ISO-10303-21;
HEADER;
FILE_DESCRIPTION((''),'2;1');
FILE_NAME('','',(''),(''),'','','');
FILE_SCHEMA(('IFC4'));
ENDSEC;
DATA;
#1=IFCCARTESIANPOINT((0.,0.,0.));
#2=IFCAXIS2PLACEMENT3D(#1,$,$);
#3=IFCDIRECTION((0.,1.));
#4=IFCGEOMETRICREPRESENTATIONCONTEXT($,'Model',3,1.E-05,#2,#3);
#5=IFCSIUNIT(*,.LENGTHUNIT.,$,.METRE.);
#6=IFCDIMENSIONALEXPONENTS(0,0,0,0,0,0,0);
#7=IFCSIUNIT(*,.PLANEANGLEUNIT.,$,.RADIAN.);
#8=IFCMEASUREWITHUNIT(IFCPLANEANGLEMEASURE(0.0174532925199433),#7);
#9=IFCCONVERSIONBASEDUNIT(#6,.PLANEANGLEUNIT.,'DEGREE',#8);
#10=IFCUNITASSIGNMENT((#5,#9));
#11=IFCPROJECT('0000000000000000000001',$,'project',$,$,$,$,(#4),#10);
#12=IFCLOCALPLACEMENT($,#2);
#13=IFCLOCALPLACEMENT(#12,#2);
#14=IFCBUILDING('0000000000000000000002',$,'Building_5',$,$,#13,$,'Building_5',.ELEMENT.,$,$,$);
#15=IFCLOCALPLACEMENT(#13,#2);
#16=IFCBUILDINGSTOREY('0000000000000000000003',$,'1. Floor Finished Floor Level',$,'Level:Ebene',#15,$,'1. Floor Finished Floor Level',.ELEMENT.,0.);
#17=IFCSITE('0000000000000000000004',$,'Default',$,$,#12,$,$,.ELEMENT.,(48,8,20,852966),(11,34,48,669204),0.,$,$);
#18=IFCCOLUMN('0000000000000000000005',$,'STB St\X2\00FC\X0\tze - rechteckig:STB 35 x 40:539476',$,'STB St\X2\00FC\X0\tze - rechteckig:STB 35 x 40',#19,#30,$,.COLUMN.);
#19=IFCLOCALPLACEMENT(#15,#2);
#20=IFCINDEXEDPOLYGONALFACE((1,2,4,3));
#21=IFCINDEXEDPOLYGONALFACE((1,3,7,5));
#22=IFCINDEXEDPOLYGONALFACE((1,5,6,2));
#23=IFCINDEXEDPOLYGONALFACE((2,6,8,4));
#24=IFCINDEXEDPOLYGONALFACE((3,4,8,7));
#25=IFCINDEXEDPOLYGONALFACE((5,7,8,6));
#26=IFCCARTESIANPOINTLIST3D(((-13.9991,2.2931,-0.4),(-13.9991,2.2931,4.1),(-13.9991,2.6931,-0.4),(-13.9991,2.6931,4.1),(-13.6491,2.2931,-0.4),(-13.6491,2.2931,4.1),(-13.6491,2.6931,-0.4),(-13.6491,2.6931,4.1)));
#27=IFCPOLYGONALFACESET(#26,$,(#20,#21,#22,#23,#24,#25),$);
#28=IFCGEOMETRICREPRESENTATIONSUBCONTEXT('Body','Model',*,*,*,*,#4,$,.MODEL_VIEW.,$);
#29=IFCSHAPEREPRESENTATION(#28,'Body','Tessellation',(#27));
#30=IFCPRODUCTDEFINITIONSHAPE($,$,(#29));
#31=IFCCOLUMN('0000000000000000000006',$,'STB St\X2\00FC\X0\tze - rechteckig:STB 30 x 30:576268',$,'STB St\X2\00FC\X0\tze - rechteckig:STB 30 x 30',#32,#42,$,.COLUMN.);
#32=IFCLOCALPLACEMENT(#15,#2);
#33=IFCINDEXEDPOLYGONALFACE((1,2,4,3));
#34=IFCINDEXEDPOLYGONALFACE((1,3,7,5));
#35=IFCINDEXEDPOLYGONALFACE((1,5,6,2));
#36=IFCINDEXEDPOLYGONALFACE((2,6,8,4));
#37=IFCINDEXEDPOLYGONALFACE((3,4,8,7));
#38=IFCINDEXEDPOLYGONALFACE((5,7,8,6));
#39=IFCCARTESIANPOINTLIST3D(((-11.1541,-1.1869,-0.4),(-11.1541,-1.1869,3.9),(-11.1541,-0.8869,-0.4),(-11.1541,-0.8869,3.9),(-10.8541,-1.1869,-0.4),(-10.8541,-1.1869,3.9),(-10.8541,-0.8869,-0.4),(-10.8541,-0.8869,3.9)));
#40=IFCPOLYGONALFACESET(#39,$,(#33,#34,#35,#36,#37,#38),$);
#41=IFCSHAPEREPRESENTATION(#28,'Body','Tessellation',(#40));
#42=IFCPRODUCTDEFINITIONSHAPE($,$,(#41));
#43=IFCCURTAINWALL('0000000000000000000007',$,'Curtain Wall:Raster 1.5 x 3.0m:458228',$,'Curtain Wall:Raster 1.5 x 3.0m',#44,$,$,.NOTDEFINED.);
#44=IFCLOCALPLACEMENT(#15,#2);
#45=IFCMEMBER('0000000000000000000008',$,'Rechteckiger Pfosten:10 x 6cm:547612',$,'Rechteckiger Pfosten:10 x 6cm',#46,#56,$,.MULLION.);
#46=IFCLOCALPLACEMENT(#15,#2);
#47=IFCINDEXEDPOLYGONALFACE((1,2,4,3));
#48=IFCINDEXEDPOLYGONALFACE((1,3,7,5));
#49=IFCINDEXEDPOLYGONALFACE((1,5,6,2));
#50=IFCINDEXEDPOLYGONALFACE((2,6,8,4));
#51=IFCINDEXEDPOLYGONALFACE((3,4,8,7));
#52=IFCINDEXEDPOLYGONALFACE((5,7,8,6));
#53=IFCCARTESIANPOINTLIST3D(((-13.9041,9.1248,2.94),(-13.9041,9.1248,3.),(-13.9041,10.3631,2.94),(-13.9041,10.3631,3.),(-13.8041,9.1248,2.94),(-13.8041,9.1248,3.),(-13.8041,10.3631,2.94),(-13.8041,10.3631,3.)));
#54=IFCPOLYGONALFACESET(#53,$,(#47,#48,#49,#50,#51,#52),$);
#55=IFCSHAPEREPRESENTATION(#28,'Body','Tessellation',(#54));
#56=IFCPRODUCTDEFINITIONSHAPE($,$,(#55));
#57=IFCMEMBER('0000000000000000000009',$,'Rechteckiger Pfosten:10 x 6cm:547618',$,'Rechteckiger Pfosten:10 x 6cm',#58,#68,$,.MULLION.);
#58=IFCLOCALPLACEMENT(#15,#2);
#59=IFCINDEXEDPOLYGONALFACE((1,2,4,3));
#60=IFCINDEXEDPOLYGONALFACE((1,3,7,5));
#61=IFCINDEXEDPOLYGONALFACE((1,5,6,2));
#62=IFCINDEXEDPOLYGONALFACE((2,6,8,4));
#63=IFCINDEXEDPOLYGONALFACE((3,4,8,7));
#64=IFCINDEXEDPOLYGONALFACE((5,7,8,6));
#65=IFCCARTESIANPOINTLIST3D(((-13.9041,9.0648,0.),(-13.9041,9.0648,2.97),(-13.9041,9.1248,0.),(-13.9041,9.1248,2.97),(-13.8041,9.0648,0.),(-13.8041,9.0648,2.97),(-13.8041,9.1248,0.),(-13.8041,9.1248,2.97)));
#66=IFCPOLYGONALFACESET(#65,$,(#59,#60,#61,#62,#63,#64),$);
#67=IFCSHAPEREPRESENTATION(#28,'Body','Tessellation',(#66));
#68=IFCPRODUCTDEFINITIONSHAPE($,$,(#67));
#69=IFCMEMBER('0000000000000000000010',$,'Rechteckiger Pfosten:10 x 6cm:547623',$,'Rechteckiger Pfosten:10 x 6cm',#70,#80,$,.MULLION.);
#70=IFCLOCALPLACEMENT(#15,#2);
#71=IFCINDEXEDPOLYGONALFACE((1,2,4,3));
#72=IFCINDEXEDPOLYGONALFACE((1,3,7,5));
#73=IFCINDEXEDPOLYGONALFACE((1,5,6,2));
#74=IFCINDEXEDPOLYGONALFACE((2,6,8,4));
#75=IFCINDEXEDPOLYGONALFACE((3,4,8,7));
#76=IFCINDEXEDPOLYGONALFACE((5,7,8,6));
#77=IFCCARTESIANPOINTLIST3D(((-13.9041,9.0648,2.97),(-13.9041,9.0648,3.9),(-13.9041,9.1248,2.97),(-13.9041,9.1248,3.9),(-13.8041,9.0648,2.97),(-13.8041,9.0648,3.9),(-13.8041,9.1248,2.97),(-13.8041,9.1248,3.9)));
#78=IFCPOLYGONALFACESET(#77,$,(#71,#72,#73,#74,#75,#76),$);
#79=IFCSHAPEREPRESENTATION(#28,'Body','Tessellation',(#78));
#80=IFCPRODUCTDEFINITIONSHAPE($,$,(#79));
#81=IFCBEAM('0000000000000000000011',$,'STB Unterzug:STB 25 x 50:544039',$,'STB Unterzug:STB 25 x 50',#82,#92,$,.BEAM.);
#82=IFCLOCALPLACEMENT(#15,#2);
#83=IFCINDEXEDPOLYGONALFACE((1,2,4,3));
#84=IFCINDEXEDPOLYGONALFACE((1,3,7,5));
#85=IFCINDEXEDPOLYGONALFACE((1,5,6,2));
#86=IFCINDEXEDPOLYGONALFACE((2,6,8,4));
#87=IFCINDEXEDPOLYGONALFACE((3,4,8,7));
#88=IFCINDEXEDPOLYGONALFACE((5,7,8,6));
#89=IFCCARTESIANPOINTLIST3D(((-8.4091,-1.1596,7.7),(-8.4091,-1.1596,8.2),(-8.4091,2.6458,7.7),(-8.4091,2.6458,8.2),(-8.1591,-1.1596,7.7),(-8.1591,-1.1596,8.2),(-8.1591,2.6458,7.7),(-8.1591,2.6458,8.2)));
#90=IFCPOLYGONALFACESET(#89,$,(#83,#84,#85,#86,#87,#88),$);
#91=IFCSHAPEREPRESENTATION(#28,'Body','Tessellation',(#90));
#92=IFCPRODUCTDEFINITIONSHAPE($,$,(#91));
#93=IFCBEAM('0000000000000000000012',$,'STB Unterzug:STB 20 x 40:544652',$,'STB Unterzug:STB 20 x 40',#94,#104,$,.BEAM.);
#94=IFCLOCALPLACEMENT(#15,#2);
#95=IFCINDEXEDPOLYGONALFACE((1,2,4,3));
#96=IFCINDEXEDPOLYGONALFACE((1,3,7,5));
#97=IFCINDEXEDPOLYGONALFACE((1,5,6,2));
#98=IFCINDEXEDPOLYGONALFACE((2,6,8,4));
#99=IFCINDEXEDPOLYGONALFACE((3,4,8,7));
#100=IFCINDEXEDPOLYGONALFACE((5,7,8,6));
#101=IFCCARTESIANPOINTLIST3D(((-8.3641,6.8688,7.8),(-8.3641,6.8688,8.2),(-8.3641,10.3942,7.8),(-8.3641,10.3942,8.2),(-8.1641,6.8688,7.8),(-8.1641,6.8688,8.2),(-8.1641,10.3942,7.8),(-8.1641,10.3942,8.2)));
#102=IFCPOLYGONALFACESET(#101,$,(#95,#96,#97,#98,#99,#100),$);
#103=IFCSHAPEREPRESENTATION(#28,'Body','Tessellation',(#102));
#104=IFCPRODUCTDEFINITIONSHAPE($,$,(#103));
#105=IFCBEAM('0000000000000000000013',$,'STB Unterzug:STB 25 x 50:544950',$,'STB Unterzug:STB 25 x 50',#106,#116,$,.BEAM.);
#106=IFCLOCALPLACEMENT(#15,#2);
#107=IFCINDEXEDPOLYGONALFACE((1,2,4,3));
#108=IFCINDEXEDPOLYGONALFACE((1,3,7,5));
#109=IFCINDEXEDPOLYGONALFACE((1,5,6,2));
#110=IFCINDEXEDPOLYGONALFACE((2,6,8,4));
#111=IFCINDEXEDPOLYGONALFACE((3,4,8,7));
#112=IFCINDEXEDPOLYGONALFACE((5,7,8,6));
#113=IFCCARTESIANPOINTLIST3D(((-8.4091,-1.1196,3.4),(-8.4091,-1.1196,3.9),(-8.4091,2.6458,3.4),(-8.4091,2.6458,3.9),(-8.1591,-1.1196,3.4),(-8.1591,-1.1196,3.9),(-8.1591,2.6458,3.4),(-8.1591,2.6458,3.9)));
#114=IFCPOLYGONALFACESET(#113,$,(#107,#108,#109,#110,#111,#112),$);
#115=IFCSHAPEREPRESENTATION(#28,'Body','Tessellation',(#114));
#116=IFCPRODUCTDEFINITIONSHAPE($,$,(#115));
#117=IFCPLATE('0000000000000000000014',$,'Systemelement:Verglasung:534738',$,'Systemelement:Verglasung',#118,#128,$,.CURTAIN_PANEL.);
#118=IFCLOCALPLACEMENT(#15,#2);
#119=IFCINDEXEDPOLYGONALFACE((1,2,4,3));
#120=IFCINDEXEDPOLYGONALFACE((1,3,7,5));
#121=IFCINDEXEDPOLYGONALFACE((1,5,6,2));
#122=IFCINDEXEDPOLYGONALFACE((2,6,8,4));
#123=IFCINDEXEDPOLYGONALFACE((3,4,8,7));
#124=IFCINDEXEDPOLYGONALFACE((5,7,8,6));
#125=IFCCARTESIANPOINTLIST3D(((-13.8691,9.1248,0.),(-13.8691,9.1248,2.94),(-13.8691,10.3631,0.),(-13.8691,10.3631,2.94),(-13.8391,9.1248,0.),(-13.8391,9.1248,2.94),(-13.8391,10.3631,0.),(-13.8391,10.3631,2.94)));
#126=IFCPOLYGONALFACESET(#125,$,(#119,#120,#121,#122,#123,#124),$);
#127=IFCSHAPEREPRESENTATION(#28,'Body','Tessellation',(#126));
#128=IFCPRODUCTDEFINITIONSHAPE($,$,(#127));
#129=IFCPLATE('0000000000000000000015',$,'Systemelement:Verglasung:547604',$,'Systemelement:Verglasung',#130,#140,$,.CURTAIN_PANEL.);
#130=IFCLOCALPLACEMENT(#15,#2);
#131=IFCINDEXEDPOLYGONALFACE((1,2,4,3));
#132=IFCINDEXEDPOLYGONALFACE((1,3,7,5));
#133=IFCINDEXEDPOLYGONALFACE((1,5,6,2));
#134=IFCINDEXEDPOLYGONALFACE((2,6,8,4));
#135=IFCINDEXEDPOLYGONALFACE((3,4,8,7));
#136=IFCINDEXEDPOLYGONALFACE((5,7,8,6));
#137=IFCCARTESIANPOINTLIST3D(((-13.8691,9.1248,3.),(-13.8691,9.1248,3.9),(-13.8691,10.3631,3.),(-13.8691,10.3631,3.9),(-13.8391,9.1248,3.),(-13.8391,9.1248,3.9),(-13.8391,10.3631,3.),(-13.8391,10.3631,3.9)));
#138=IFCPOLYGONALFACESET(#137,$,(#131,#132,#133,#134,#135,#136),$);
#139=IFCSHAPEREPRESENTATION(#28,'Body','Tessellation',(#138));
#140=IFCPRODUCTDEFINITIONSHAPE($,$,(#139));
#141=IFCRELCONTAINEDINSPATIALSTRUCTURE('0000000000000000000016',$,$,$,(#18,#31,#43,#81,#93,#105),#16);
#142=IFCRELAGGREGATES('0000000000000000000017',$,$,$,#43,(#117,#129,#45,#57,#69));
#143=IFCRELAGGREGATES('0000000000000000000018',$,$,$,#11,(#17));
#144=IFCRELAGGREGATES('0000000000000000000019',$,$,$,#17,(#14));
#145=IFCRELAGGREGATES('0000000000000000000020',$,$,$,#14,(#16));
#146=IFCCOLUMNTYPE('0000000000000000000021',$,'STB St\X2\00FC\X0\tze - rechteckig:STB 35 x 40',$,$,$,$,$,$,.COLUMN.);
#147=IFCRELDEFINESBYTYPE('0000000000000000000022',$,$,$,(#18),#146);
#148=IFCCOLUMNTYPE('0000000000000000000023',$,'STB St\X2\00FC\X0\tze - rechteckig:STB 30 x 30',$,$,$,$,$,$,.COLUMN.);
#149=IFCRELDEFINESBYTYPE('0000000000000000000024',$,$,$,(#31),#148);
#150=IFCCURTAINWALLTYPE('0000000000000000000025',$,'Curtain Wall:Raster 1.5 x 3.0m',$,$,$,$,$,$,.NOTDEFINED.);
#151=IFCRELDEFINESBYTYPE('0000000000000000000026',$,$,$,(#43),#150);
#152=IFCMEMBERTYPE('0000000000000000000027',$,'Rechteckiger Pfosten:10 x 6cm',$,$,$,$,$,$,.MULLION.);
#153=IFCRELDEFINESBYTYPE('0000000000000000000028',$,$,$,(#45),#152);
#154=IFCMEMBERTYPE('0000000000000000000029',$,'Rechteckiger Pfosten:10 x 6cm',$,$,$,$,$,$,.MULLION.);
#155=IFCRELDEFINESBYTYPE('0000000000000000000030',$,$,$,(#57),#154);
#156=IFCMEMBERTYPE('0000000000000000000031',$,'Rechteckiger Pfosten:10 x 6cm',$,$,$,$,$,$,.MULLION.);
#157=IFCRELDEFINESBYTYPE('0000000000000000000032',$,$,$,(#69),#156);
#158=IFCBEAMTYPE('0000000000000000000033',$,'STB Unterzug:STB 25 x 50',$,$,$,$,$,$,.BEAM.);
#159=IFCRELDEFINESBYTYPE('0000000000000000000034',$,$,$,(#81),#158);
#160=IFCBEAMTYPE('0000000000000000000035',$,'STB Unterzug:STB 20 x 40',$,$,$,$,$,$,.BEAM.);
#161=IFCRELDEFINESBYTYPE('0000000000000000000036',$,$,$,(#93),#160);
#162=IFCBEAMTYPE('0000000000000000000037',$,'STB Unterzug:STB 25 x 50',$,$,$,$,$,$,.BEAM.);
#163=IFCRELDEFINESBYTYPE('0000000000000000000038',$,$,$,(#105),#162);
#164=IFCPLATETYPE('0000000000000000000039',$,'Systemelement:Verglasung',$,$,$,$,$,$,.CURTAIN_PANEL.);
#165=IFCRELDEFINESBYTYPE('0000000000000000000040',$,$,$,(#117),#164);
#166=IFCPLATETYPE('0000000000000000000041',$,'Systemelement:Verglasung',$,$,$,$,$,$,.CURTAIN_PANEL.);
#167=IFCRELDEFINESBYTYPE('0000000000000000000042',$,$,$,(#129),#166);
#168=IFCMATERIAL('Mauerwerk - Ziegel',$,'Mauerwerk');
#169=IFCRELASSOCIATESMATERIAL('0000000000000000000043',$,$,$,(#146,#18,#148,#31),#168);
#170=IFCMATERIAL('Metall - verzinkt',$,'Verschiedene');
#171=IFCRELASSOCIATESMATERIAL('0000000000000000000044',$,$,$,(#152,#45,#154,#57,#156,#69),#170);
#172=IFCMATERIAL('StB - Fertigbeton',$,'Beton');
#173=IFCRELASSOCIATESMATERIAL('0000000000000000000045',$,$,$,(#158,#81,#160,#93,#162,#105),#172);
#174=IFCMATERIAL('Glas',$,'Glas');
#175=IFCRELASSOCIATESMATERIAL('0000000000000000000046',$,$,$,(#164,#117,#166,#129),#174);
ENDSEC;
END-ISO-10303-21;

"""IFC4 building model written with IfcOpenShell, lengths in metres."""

from ifc_helpers import new_model, entity, si_unit, converted_unit, direction, frame, origin, place, context, subcontext, project, spatial, indexed_curve, outline, extrude, source, transform, mapped, material, type_object, type_shapes, element, aggregate, save


model = new_model("IFC4")

# Units and contexts
model_context = context("Model", 3, precision=1e-05, world=origin(), true_north=direction((0.0, 1.0)))
body_context = subcontext(model_context, "Body", "Model", "MODEL_VIEW")
ifc_project = project(units=[si_unit("LENGTHUNIT", "METRE"), converted_unit("PLANEANGLEUNIT", "DEGREE", entity("IfcPlaneAngleMeasure", 0.0174532925199433), si_unit("PLANEANGLEUNIT", "RADIAN"), dimensions=[0, 0, 0, 0, 0, 0, 0])], contexts=[model_context])

# Site, building, storey
site_placement = place(None, origin())
site = spatial("IfcSite", under=ifc_project, at=site_placement, Name="Default", CompositionType="ELEMENT", RefLatitude=(48, 8, 20, 852966), RefLongitude=(11, 34, 48, 669204), RefElevation=0.0)
building_placement = place(site_placement, origin())
building = spatial("IfcBuilding", under=site, at=building_placement, Name="Building_5", LongName="Building_5", CompositionType="ELEMENT")
storey_placement = place(building_placement, origin())
storey = spatial("IfcBuildingStorey", under=building, at=storey_placement, Name="1. Floor Finished Floor Level", ObjectType="Level:Ebene", LongName="1. Floor Finished Floor Level", CompositionType="ELEMENT", Elevation=0.0)

# Columns
ifc_material_1 = material(Name="Mauerwerk - Ziegel", Category="Mauerwerk")
column_type_1 = type_object("IfcColumnType", Name="STB Stütze - rechteckig:STB 35 x 40", PredefinedType="COLUMN", material=ifc_material_1)
shared_shape_1 = source(origin(), body_context, "Body", "SweptSolid", [
    extrude(outline(indexed_curve([(-0.175, -0.2), (0.175, -0.2), (0.175, 0.2), (-0.175, 0.2), (-0.175, -0.2)], self_intersect=False)), frame((0.0, 0.0, -0.4), z_axis=(0.0, 0.0, 1.0), x_axis=(-1.0, 0.0, 0.0)), (0.0, 0.0, 1.0), 4.5),
])
type_shapes(column_type_1, [shared_shape_1])
column_1_placement = place(storey_placement, frame((-13.8241, 2.4931, 0.0)))
element("IfcColumn", 1, at=column_1_placement, inside=storey, type_object=column_type_1, material=ifc_material_1, Name="STB Stütze - rechteckig:STB 35 x 40:539476", ObjectType="STB Stütze - rechteckig:STB 35 x 40", PredefinedType="COLUMN", context=body_context, shape_type="MappedRepresentation", body=[
    mapped(shared_shape_1, transform((0.0, 0.0, 0.0), scale=1.0)),
])
column_type_2 = type_object("IfcColumnType", Name="STB Stütze - rechteckig:STB 30 x 30", PredefinedType="COLUMN", material=ifc_material_1)
shared_shape_2 = source(origin(), body_context, "Body", "SweptSolid", [
    extrude(outline(indexed_curve([(-0.15, -0.15), (0.15, -0.15), (0.15, 0.15), (-0.15, 0.15), (-0.15, -0.15)], self_intersect=False)), frame((0.0, 0.0, -0.4), z_axis=(0.0, 0.0, 1.0), x_axis=(-1.0, 0.0, 0.0)), (0.0, 0.0, 1.0), 4.3),
])
type_shapes(column_type_2, [shared_shape_2])
column_2_placement = place(storey_placement, frame((-11.0041, -1.0369, 0.0)))
element("IfcColumn", 2, at=column_2_placement, inside=storey, type_object=column_type_2, material=ifc_material_1, Name="STB Stütze - rechteckig:STB 30 x 30:576268", ObjectType="STB Stütze - rechteckig:STB 30 x 30", PredefinedType="COLUMN", context=body_context, shape_type="MappedRepresentation", body=[
    mapped(shared_shape_2, transform((0.0, 0.0, 0.0), scale=1.0)),
])

# Curtain wall, members
curtain_wall_type = type_object("IfcCurtainWallType", Name="Curtain Wall:Raster 1.5 x 3.0m", PredefinedType="NOTDEFINED")
curtain_wall_placement = place(storey_placement, origin())
curtain_wall = element("IfcCurtainWall", 3, at=curtain_wall_placement, inside=storey, type_object=curtain_wall_type, Name="Curtain Wall:Raster 1.5 x 3.0m:458228", ObjectType="Curtain Wall:Raster 1.5 x 3.0m", PredefinedType="NOTDEFINED")
ifc_material_2 = material(Name="Metall - verzinkt", Category="Verschiedene")
member_type_1 = type_object("IfcMemberType", Name="Rechteckiger Pfosten:10 x 6cm", PredefinedType="MULLION", material=ifc_material_2)
shared_shape_3 = source(origin(), body_context, "Body", "SweptSolid", [
    extrude(outline(indexed_curve([(-0.03, -0.05), (0.03, -0.05), (0.03, 0.05), (-0.03, 0.05), (-0.03, -0.05)], self_intersect=False)), frame((0.0, 0.0, -1.2383), z_axis=(0.0, 0.0, 1.0), x_axis=(-1.0, 0.0, 0.0)), (0.0, 0.0, 1.0), 1.2383),
])
type_shapes(member_type_1, [shared_shape_3])
member_1_placement = place(curtain_wall_placement, frame((-13.8541, 9.1248, 2.97), z_axis=(0.0, -1.0, 0.0), x_axis=(0.0, 0.0, 1.0)))
member_1 = element("IfcMember", 4, at=member_1_placement, type_object=member_type_1, material=ifc_material_2, Name="Rechteckiger Pfosten:10 x 6cm:547612", ObjectType="Rechteckiger Pfosten:10 x 6cm", PredefinedType="MULLION", context=body_context, shape_type="MappedRepresentation", body=[
    mapped(shared_shape_3, transform((0.0, 0.0, 0.0), scale=1.0)),
])
member_type_2 = type_object("IfcMemberType", Name="Rechteckiger Pfosten:10 x 6cm", PredefinedType="MULLION", material=ifc_material_2)
shared_shape_4 = source(origin(), body_context, "Body", "SweptSolid", [
    extrude(outline(indexed_curve([(-0.03, -0.05), (0.03, -0.05), (0.03, 0.05), (-0.03, 0.05), (-0.03, -0.05)], self_intersect=False)), frame((0.0, 0.0, -2.97), z_axis=(0.0, 0.0, 1.0), x_axis=(-1.0, 0.0, 0.0)), (0.0, 0.0, 1.0), 2.97),
])
type_shapes(member_type_2, [shared_shape_4])
member_2_placement = place(curtain_wall_placement, frame((-13.8541, 9.0948, 0.0), z_axis=(0.0, 0.0, -1.0), x_axis=(0.0, -1.0, 0.0)))
member_2 = element("IfcMember", 5, at=member_2_placement, type_object=member_type_2, material=ifc_material_2, Name="Rechteckiger Pfosten:10 x 6cm:547618", ObjectType="Rechteckiger Pfosten:10 x 6cm", PredefinedType="MULLION", context=body_context, shape_type="MappedRepresentation", body=[
    mapped(shared_shape_4, transform((0.0, 0.0, 0.0), scale=1.0)),
])
member_type_3 = type_object("IfcMemberType", Name="Rechteckiger Pfosten:10 x 6cm", PredefinedType="MULLION", material=ifc_material_2)
shared_shape_5 = source(origin(), body_context, "Body", "SweptSolid", [
    extrude(outline(indexed_curve([(-0.03, -0.05), (0.03, -0.05), (0.03, 0.05), (-0.03, 0.05), (-0.03, -0.05)], self_intersect=False)), frame((0.0, 0.0, -0.93), z_axis=(0.0, 0.0, 1.0), x_axis=(-1.0, 0.0, 0.0)), (0.0, 0.0, 1.0), 0.93),
])
type_shapes(member_type_3, [shared_shape_5])
member_3_placement = place(curtain_wall_placement, frame((-13.8541, 9.0948, 2.97), z_axis=(0.0, 0.0, -1.0), x_axis=(0.0, -1.0, 0.0)))
member_3 = element("IfcMember", 6, at=member_3_placement, type_object=member_type_3, material=ifc_material_2, Name="Rechteckiger Pfosten:10 x 6cm:547623", ObjectType="Rechteckiger Pfosten:10 x 6cm", PredefinedType="MULLION", context=body_context, shape_type="MappedRepresentation", body=[
    mapped(shared_shape_5, transform((0.0, 0.0, 0.0), scale=1.0)),
])

# Beams
ifc_material_3 = material(Name="StB - Fertigbeton", Category="Beton")
beam_type_1 = type_object("IfcBeamType", Name="STB Unterzug:STB 25 x 50", PredefinedType="BEAM", material=ifc_material_3)
shared_shape_6 = source(origin(), body_context, "Body", "SweptSolid", [
    extrude(outline(indexed_curve([(-1.9027, -0.125), (1.9027, -0.125), (1.9027, 0.125), (-1.9027, 0.125), (-1.9027, -0.125)], self_intersect=False)), frame((0.0, 0.0, -0.25), z_axis=(0.0, 0.0, 1.0), x_axis=(-1.0, 0.0, 0.0)), (0.0, 0.0, 1.0), 0.5),
])
type_shapes(beam_type_1, [shared_shape_6])
beam_1_placement = place(storey_placement, frame((-8.2841, 0.7431, 7.95), z_axis=(0.0, 0.0, 1.0), x_axis=(0.0, 1.0, 0.0)))
element("IfcBeam", 7, at=beam_1_placement, inside=storey, type_object=beam_type_1, material=ifc_material_3, Name="STB Unterzug:STB 25 x 50:544039", ObjectType="STB Unterzug:STB 25 x 50", PredefinedType="BEAM", context=body_context, shape_type="MappedRepresentation", body=[
    mapped(shared_shape_6, transform((0.0, 0.0, 0.0), scale=1.0)),
])
beam_type_2 = type_object("IfcBeamType", Name="STB Unterzug:STB 20 x 40", PredefinedType="BEAM", material=ifc_material_3)
shared_shape_7 = source(origin(), body_context, "Body", "SweptSolid", [
    extrude(outline(indexed_curve([(-1.7627, -0.1), (1.7627, -0.1), (1.7627, 0.1), (-1.7627, 0.1), (-1.7627, -0.1)], self_intersect=False)), frame((0.0, 0.0, -0.2), z_axis=(0.0, 0.0, 1.0), x_axis=(-1.0, 0.0, 0.0)), (0.0, 0.0, 1.0), 0.4),
])
type_shapes(beam_type_2, [shared_shape_7])
beam_2_placement = place(storey_placement, frame((-8.2641, 8.6315, 8.0), z_axis=(0.0, 0.0, 1.0), x_axis=(0.0, 1.0, 0.0)))
element("IfcBeam", 8, at=beam_2_placement, inside=storey, type_object=beam_type_2, material=ifc_material_3, Name="STB Unterzug:STB 20 x 40:544652", ObjectType="STB Unterzug:STB 20 x 40", PredefinedType="BEAM", context=body_context, shape_type="MappedRepresentation", body=[
    mapped(shared_shape_7, transform((0.0, 0.0, 0.0), scale=1.0)),
])
beam_type_3 = type_object("IfcBeamType", Name="STB Unterzug:STB 25 x 50", PredefinedType="BEAM", material=ifc_material_3)
shared_shape_8 = source(origin(), body_context, "Body", "SweptSolid", [
    extrude(outline(indexed_curve([(-1.8827, -0.125), (1.8827, -0.125), (1.8827, 0.125), (-1.8827, 0.125), (-1.8827, -0.125)], self_intersect=False)), frame((0.0, 0.0, -0.25), z_axis=(0.0, 0.0, 1.0), x_axis=(-1.0, 0.0, 0.0)), (0.0, 0.0, 1.0), 0.5),
])
type_shapes(beam_type_3, [shared_shape_8])
beam_3_placement = place(storey_placement, frame((-8.2841, 0.7631, 3.65), z_axis=(0.0, 0.0, 1.0), x_axis=(0.0, 1.0, 0.0)))
element("IfcBeam", 9, at=beam_3_placement, inside=storey, type_object=beam_type_3, material=ifc_material_3, Name="STB Unterzug:STB 25 x 50:544950", ObjectType="STB Unterzug:STB 25 x 50", PredefinedType="BEAM", context=body_context, shape_type="MappedRepresentation", body=[
    mapped(shared_shape_8, transform((0.0, 0.0, 0.0), scale=1.0)),
])

# Plates
ifc_material_4 = material(Name="Glas", Category="Glas")
plate_type_1 = type_object("IfcPlateType", Name="Systemelement:Verglasung", PredefinedType="CURTAIN_PANEL", material=ifc_material_4)
shared_shape_9 = source(origin(), body_context, "Body", "SweptSolid", [
    extrude(outline(indexed_curve([(-0.015, -0.6192), (0.015, -0.6192), (0.015, 0.6192), (-0.015, 0.6192), (-0.015, -0.6192)], self_intersect=False)), frame((0.0, 0.0, 0.0), z_axis=(0.0, 0.0, 1.0), x_axis=(0.0, 1.0, 0.0)), (0.0, 0.0, 1.0), 2.94),
])
type_shapes(plate_type_1, [shared_shape_9])
plate_1_placement = place(curtain_wall_placement, frame((-13.8541, 9.744, 0.0), z_axis=(0.0, 0.0, 1.0), x_axis=(0.0, -1.0, 0.0)))
plate_1 = element("IfcPlate", 10, at=plate_1_placement, type_object=plate_type_1, material=ifc_material_4, Name="Systemelement:Verglasung:534738", ObjectType="Systemelement:Verglasung", PredefinedType="CURTAIN_PANEL", context=body_context, shape_type="MappedRepresentation", body=[
    mapped(shared_shape_9, transform((0.0, 0.0, 0.0), scale=1.0)),
])
plate_type_2 = type_object("IfcPlateType", Name="Systemelement:Verglasung", PredefinedType="CURTAIN_PANEL", material=ifc_material_4)
shared_shape_10 = source(origin(), body_context, "Body", "SweptSolid", [
    extrude(outline(indexed_curve([(-0.015, -0.6192), (0.015, -0.6192), (0.015, 0.6192), (-0.015, 0.6192), (-0.015, -0.6192)], self_intersect=False)), frame((0.0, 0.0, 0.0), z_axis=(0.0, 0.0, 1.0), x_axis=(0.0, 1.0, 0.0)), (0.0, 0.0, 1.0), 0.9),
])
type_shapes(plate_type_2, [shared_shape_10])
plate_2_placement = place(curtain_wall_placement, frame((-13.8541, 9.744, 3.0), z_axis=(0.0, 0.0, 1.0), x_axis=(0.0, -1.0, 0.0)))
plate_2 = element("IfcPlate", 11, at=plate_2_placement, type_object=plate_type_2, material=ifc_material_4, Name="Systemelement:Verglasung:547604", ObjectType="Systemelement:Verglasung", PredefinedType="CURTAIN_PANEL", context=body_context, shape_type="MappedRepresentation", body=[
    mapped(shared_shape_10, transform((0.0, 0.0, 0.0), scale=1.0)),
])
aggregate(curtain_wall, [plate_1, plate_2, member_1, member_2, member_3])

save(model, "model.ifc")
